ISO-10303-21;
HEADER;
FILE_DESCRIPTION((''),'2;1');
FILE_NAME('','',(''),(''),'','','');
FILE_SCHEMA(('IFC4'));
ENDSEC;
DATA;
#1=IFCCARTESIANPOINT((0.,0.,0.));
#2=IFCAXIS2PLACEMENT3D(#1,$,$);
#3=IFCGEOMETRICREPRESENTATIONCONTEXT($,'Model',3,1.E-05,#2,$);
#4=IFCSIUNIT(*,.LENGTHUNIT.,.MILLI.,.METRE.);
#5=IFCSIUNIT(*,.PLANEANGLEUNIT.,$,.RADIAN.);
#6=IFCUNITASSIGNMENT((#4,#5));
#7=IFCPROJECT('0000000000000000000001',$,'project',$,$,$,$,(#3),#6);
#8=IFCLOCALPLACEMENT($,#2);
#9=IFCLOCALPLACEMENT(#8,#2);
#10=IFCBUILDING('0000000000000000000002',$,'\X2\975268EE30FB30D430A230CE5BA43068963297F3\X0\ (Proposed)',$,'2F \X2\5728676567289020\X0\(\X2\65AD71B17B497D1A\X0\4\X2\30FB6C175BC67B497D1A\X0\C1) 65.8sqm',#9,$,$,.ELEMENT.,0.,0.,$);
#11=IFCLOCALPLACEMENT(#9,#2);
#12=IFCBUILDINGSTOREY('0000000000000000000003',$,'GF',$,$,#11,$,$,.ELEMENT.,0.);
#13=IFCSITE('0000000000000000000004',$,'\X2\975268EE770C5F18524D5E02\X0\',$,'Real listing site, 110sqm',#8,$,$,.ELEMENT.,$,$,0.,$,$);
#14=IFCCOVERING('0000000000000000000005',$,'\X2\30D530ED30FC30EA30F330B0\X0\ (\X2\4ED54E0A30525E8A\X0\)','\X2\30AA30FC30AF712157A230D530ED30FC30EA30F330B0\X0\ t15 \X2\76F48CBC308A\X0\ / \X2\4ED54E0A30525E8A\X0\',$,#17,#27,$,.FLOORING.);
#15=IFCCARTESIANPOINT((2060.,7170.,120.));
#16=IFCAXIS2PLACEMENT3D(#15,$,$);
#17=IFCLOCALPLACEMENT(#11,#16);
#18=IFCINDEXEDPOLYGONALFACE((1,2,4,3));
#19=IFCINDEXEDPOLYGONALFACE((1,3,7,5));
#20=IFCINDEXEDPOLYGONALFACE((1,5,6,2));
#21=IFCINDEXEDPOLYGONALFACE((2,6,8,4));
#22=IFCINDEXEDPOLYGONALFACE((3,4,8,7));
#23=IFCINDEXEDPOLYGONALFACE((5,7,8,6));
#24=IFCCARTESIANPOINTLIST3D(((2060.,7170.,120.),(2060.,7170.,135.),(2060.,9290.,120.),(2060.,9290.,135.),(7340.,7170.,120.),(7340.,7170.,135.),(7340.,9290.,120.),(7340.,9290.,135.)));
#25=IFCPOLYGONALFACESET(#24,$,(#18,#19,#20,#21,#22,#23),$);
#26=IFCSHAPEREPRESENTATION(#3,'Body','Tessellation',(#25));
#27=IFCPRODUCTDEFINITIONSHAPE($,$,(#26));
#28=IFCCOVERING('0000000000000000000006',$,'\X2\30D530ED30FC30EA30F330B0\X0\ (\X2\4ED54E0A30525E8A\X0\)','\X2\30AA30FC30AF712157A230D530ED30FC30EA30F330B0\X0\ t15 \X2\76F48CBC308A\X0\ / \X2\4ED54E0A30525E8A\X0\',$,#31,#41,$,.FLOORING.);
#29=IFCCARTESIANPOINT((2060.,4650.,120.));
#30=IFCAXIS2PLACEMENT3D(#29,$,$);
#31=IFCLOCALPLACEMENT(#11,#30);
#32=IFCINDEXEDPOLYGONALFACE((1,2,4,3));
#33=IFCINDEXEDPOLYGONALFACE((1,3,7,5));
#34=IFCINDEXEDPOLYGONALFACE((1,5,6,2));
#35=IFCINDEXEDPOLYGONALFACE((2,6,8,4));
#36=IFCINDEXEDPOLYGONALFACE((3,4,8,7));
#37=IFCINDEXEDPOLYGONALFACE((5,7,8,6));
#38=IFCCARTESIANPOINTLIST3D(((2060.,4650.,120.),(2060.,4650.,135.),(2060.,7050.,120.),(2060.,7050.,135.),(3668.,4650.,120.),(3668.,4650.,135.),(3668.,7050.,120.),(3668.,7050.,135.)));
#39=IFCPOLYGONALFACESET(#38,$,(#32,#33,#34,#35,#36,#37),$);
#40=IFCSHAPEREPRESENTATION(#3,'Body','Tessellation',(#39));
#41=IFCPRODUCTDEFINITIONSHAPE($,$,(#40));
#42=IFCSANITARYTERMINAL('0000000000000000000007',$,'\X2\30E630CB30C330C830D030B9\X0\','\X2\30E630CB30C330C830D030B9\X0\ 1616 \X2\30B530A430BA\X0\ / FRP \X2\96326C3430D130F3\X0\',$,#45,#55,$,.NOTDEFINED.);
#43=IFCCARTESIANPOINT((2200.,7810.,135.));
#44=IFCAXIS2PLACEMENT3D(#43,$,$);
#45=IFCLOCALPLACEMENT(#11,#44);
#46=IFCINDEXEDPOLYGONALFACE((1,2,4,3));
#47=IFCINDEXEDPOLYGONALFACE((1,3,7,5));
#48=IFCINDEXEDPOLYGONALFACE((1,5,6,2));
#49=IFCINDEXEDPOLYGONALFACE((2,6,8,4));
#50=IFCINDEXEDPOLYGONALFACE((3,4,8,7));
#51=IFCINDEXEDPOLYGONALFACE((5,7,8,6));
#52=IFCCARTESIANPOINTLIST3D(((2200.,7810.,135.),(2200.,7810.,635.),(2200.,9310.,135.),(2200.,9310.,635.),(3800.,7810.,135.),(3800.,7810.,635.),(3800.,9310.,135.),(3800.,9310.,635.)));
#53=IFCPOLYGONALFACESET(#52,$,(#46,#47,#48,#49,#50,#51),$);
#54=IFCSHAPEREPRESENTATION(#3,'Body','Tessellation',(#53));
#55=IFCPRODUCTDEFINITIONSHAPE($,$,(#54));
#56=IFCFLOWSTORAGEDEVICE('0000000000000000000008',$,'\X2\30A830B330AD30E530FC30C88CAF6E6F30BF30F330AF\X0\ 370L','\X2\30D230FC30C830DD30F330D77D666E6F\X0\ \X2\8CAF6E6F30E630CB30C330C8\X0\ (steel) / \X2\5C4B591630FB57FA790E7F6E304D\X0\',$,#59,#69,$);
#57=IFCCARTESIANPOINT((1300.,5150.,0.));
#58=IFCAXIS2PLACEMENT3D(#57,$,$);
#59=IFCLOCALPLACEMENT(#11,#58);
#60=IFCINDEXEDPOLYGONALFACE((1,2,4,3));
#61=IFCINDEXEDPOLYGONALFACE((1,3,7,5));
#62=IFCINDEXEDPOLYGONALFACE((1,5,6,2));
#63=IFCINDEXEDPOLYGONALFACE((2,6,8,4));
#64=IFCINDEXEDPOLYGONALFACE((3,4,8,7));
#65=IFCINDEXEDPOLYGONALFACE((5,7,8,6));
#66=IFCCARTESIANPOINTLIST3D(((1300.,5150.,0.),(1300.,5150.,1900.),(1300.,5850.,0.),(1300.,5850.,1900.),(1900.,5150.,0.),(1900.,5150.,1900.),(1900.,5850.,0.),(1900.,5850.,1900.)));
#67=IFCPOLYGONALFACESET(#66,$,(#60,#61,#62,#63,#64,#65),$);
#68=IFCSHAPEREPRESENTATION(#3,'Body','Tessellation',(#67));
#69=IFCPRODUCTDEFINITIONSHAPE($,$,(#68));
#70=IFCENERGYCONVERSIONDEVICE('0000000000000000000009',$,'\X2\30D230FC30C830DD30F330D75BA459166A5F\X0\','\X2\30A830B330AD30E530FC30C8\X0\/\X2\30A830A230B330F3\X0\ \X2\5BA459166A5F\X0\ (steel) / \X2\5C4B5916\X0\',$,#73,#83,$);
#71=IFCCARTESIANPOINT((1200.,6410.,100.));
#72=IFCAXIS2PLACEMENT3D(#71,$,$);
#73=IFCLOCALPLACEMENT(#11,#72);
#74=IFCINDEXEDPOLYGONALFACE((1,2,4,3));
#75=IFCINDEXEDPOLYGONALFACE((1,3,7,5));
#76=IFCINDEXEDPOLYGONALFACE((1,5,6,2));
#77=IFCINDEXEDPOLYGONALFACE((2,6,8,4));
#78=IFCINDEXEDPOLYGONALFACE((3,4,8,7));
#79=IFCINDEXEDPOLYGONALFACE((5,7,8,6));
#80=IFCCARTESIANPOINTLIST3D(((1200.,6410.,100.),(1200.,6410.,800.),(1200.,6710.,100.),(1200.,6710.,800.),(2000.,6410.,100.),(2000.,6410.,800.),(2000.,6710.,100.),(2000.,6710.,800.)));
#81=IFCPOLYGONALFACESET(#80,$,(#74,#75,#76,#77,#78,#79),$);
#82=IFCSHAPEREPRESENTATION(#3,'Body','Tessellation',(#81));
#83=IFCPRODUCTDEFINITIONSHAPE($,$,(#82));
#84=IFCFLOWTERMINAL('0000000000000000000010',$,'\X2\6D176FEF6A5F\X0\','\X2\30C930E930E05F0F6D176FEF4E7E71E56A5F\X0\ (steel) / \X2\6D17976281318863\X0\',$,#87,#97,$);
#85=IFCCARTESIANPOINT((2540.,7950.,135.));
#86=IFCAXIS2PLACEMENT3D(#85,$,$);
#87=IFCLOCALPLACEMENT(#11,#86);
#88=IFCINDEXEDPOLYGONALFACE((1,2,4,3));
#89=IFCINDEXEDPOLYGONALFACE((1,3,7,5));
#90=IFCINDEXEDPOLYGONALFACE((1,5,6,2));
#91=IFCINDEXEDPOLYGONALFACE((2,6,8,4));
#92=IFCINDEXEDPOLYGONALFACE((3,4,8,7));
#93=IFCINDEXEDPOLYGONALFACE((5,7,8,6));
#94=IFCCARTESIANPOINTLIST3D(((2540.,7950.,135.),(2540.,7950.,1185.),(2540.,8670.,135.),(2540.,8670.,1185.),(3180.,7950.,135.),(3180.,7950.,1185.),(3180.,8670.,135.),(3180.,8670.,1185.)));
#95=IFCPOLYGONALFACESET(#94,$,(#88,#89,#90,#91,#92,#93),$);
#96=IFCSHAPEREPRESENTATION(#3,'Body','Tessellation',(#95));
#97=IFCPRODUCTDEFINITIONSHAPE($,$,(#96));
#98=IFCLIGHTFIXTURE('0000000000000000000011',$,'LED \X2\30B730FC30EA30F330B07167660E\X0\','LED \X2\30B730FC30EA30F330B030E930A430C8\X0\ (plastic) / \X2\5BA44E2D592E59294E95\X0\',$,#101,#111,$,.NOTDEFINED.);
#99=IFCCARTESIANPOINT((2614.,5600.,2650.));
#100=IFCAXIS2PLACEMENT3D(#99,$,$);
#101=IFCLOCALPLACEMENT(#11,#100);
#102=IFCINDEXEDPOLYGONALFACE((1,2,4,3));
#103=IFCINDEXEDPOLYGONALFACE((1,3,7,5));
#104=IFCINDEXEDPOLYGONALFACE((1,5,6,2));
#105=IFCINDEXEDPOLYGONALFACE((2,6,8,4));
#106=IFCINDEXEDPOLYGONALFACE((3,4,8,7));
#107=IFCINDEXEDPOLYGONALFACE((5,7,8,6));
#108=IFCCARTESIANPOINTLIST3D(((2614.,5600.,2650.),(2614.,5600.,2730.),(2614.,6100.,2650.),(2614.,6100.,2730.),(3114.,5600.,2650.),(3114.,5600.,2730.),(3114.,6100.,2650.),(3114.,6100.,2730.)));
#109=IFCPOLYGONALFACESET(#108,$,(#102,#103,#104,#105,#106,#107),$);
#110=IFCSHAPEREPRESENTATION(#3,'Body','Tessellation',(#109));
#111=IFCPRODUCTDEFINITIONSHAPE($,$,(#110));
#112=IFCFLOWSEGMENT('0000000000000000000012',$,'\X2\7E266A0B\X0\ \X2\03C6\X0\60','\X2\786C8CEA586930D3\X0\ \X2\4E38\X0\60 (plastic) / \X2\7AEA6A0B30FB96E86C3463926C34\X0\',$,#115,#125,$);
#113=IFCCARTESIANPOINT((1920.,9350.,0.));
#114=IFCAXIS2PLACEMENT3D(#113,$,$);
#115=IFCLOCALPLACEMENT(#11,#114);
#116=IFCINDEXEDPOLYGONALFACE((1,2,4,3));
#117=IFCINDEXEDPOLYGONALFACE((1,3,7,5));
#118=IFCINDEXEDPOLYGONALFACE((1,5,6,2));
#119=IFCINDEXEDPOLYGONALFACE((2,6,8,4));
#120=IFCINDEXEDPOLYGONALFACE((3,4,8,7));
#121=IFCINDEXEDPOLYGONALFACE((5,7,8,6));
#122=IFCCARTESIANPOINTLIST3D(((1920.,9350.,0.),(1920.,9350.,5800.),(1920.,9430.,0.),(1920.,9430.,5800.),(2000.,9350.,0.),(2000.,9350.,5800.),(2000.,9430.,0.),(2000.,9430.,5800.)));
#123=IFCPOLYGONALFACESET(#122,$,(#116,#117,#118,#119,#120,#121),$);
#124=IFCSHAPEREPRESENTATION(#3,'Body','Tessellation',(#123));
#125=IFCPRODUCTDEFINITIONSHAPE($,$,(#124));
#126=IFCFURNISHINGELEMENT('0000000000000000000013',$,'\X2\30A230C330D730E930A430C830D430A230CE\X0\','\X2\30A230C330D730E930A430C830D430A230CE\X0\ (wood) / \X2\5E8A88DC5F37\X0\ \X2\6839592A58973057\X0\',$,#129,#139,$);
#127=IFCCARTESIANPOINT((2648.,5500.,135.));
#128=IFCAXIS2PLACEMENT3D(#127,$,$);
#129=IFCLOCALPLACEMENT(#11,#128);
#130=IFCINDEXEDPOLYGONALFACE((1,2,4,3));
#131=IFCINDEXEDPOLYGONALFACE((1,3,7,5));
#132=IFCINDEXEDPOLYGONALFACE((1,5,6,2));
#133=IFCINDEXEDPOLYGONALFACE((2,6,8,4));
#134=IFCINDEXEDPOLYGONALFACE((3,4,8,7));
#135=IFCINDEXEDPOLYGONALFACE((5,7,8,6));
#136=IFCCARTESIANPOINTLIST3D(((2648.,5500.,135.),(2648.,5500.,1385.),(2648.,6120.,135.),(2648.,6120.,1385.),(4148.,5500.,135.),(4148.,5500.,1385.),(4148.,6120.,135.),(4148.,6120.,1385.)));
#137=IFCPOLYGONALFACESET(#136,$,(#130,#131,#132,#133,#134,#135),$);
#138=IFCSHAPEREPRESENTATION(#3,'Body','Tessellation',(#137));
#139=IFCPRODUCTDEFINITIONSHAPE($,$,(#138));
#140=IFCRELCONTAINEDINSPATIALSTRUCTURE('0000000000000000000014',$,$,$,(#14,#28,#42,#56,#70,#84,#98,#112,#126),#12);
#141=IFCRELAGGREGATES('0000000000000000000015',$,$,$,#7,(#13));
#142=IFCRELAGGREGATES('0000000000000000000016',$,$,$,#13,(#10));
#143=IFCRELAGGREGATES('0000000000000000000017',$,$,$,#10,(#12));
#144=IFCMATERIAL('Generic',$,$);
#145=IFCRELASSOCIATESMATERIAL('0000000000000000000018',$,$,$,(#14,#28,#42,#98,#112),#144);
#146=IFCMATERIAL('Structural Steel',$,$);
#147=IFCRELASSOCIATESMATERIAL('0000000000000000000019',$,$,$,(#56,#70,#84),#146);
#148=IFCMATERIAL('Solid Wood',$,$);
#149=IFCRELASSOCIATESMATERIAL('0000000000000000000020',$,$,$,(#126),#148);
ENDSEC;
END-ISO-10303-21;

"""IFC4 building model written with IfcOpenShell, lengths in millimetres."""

from ifc_helpers import new_model, si_unit, frame, frame_2d, origin, place, context, project, spatial, rectangle, extrude, material, element, save


model = new_model("IFC4")

# Units and contexts
model_context = context("Model", 3, precision=1e-05, world=origin())
ifc_project = project(units=[si_unit("LENGTHUNIT", "METRE", prefix="MILLI"), si_unit("PLANEANGLEUNIT", "RADIAN")], contexts=[model_context])

# Site, building, storey
site_placement = place(None, origin())
site = spatial("IfcSite", under=ifc_project, at=site_placement, Name="青森県弘前市", ObjectType="Real listing site, 110sqm", CompositionType="ELEMENT", RefElevation=0.0)
building_placement = place(site_placement, origin())
building = spatial("IfcBuilding", under=site, at=building_placement, Name="青森・ピアノ室と防音 (Proposed)", ObjectType="2F 在来木造(断熱等級4・気密等級C1) 65.8sqm", CompositionType="ELEMENT", ElevationOfRefHeight=0.0, ElevationOfTerrain=0.0)
storey_placement = place(building_placement, origin())
storey = spatial("IfcBuildingStorey", under=building, at=storey_placement, Name="GF", CompositionType="ELEMENT", Elevation=0.0)

# Shared definitions
ifc_material_1 = material(Name="Solid Wood")

# Coverings
ifc_material_2 = material(Name="Generic")
covering_1_placement = place(storey_placement, frame((2060.0, 7170.0, 120.0)))
element("IfcCovering", 1, at=covering_1_placement, inside=storey, material=ifc_material_2, Name="フローリング (仕上げ床)", Description="オーク無垢フローリング t15 直貼り / 仕上げ床", PredefinedType="FLOORING", context=model_context, shape_type="SweptSolid", body=[
    extrude(rectangle(XDim=5280.0, YDim=2120.0, at=frame_2d((2640.0, 1060.0))), frame((2060.0, 7170.0, 120.0)), (0.0, 0.0, 1.0), 15.0),
])
covering_2_placement = place(storey_placement, frame((2060.0, 4650.0, 120.0)))
element("IfcCovering", 2, at=covering_2_placement, inside=storey, material=ifc_material_2, Name="フローリング (仕上げ床)", Description="オーク無垢フローリング t15 直貼り / 仕上げ床", PredefinedType="FLOORING", context=model_context, shape_type="SweptSolid", body=[
    extrude(rectangle(XDim=1608.0, YDim=2400.0, at=frame_2d((804.0, 1200.0))), frame((2060.0, 4650.0, 120.0)), (0.0, 0.0, 1.0), 15.0),
])

# Sanitary terminal
sanitary_terminal_placement = place(storey_placement, frame((2200.0, 7810.0, 135.0)))
element("IfcSanitaryTerminal", 3, at=sanitary_terminal_placement, inside=storey, material=ifc_material_2, Name="ユニットバス", Description="ユニットバス 1616 サイズ / FRP 防水パン", PredefinedType="NOTDEFINED", context=model_context, shape_type="SweptSolid", body=[
    extrude(rectangle(XDim=1600.0, YDim=1500.0, at=frame_2d((800.0, 750.0))), frame((2200.0, 7810.0, 135.0)), (0.0, 0.0, 1.0), 500.0),
])

# Flow storage device
ifc_material_3 = material(Name="Structural Steel")
flow_storage_device_placement = place(storey_placement, frame((1300.0, 5150.0, 0.0)))
element("IfcFlowStorageDevice", 4, at=flow_storage_device_placement, inside=storey, material=ifc_material_3, Name="エコキュート貯湯タンク 370L", Description="ヒートポンプ給湯 貯湯ユニット (steel) / 屋外・基礎置き", context=model_context, shape_type="SweptSolid", body=[
    extrude(rectangle(XDim=600.0, YDim=700.0, at=frame_2d((300.0, 350.0))), frame((1300.0, 5150.0, 0.0)), (0.0, 0.0, 1.0), 1900.0),
])

# Energy conversion device
energy_conversion_device_placement = place(storey_placement, frame((1200.0, 6410.0, 100.0)))
element("IfcEnergyConversionDevice", 5, at=energy_conversion_device_placement, inside=storey, material=ifc_material_3, Name="ヒートポンプ室外機", Description="エコキュート/エアコン 室外機 (steel) / 屋外", context=model_context, shape_type="SweptSolid", body=[
    extrude(rectangle(XDim=800.0, YDim=300.0, at=frame_2d((400.0, 150.0))), frame((1200.0, 6410.0, 100.0)), (0.0, 0.0, 1.0), 700.0),
])

# Flow terminal
flow_terminal_placement = place(storey_placement, frame((2540.0, 7950.0, 135.0)))
element("IfcFlowTerminal", 6, at=flow_terminal_placement, inside=storey, material=ifc_material_3, Name="洗濯機", Description="ドラム式洗濯乾燥機 (steel) / 洗面脱衣", context=model_context, shape_type="SweptSolid", body=[
    extrude(rectangle(XDim=640.0, YDim=720.0, at=frame_2d((320.0, 360.0))), frame((2540.0, 7950.0, 135.0)), (0.0, 0.0, 1.0), 1050.0),
])

# Light fixture
light_fixture_placement = place(storey_placement, frame((2614.0, 5600.0, 2650.0)))
element("IfcLightFixture", 7, at=light_fixture_placement, inside=storey, material=ifc_material_2, Name="LED シーリング照明", Description="LED シーリングライト (plastic) / 室中央天井", PredefinedType="NOTDEFINED", context=model_context, shape_type="SweptSolid", body=[
    extrude(rectangle(XDim=500.0, YDim=500.0, at=frame_2d((250.0, 250.0))), frame((2614.0, 5600.0, 2650.0)), (0.0, 0.0, 1.0), 80.0),
])

# Flow segment
flow_segment_placement = place(storey_placement, frame((1920.0, 9350.0, 0.0)))
element("IfcFlowSegment", 8, at=flow_segment_placement, inside=storey, material=ifc_material_2, Name="縦樋 φ60", Description="硬質塩ビ 丸60 (plastic) / 竪樋・雨水排水", context=model_context, shape_type="SweptSolid", body=[
    extrude(rectangle(XDim=80.0, YDim=80.0, at=frame_2d((40.0, 40.0))), frame((1920.0, 9350.0, 0.0)), (0.0, 0.0, 1.0), 5800.0),
])

# Furnishing element
furnishing_placement = place(storey_placement, frame((2648.0, 5500.0, 135.0)))
element("IfcFurnishingElement", 9, at=furnishing_placement, inside=storey, material=ifc_material_1, Name="アップライトピアノ", Description="アップライトピアノ (wood) / 床補強 根太増し", context=model_context, shape_type="SweptSolid", body=[
    extrude(rectangle(XDim=1500.0, YDim=620.0, at=frame_2d((750.0, 310.0))), frame((2648.0, 5500.0, 135.0)), (0.0, 0.0, 1.0), 1250.0),
])

save(model, "model.ifc")
